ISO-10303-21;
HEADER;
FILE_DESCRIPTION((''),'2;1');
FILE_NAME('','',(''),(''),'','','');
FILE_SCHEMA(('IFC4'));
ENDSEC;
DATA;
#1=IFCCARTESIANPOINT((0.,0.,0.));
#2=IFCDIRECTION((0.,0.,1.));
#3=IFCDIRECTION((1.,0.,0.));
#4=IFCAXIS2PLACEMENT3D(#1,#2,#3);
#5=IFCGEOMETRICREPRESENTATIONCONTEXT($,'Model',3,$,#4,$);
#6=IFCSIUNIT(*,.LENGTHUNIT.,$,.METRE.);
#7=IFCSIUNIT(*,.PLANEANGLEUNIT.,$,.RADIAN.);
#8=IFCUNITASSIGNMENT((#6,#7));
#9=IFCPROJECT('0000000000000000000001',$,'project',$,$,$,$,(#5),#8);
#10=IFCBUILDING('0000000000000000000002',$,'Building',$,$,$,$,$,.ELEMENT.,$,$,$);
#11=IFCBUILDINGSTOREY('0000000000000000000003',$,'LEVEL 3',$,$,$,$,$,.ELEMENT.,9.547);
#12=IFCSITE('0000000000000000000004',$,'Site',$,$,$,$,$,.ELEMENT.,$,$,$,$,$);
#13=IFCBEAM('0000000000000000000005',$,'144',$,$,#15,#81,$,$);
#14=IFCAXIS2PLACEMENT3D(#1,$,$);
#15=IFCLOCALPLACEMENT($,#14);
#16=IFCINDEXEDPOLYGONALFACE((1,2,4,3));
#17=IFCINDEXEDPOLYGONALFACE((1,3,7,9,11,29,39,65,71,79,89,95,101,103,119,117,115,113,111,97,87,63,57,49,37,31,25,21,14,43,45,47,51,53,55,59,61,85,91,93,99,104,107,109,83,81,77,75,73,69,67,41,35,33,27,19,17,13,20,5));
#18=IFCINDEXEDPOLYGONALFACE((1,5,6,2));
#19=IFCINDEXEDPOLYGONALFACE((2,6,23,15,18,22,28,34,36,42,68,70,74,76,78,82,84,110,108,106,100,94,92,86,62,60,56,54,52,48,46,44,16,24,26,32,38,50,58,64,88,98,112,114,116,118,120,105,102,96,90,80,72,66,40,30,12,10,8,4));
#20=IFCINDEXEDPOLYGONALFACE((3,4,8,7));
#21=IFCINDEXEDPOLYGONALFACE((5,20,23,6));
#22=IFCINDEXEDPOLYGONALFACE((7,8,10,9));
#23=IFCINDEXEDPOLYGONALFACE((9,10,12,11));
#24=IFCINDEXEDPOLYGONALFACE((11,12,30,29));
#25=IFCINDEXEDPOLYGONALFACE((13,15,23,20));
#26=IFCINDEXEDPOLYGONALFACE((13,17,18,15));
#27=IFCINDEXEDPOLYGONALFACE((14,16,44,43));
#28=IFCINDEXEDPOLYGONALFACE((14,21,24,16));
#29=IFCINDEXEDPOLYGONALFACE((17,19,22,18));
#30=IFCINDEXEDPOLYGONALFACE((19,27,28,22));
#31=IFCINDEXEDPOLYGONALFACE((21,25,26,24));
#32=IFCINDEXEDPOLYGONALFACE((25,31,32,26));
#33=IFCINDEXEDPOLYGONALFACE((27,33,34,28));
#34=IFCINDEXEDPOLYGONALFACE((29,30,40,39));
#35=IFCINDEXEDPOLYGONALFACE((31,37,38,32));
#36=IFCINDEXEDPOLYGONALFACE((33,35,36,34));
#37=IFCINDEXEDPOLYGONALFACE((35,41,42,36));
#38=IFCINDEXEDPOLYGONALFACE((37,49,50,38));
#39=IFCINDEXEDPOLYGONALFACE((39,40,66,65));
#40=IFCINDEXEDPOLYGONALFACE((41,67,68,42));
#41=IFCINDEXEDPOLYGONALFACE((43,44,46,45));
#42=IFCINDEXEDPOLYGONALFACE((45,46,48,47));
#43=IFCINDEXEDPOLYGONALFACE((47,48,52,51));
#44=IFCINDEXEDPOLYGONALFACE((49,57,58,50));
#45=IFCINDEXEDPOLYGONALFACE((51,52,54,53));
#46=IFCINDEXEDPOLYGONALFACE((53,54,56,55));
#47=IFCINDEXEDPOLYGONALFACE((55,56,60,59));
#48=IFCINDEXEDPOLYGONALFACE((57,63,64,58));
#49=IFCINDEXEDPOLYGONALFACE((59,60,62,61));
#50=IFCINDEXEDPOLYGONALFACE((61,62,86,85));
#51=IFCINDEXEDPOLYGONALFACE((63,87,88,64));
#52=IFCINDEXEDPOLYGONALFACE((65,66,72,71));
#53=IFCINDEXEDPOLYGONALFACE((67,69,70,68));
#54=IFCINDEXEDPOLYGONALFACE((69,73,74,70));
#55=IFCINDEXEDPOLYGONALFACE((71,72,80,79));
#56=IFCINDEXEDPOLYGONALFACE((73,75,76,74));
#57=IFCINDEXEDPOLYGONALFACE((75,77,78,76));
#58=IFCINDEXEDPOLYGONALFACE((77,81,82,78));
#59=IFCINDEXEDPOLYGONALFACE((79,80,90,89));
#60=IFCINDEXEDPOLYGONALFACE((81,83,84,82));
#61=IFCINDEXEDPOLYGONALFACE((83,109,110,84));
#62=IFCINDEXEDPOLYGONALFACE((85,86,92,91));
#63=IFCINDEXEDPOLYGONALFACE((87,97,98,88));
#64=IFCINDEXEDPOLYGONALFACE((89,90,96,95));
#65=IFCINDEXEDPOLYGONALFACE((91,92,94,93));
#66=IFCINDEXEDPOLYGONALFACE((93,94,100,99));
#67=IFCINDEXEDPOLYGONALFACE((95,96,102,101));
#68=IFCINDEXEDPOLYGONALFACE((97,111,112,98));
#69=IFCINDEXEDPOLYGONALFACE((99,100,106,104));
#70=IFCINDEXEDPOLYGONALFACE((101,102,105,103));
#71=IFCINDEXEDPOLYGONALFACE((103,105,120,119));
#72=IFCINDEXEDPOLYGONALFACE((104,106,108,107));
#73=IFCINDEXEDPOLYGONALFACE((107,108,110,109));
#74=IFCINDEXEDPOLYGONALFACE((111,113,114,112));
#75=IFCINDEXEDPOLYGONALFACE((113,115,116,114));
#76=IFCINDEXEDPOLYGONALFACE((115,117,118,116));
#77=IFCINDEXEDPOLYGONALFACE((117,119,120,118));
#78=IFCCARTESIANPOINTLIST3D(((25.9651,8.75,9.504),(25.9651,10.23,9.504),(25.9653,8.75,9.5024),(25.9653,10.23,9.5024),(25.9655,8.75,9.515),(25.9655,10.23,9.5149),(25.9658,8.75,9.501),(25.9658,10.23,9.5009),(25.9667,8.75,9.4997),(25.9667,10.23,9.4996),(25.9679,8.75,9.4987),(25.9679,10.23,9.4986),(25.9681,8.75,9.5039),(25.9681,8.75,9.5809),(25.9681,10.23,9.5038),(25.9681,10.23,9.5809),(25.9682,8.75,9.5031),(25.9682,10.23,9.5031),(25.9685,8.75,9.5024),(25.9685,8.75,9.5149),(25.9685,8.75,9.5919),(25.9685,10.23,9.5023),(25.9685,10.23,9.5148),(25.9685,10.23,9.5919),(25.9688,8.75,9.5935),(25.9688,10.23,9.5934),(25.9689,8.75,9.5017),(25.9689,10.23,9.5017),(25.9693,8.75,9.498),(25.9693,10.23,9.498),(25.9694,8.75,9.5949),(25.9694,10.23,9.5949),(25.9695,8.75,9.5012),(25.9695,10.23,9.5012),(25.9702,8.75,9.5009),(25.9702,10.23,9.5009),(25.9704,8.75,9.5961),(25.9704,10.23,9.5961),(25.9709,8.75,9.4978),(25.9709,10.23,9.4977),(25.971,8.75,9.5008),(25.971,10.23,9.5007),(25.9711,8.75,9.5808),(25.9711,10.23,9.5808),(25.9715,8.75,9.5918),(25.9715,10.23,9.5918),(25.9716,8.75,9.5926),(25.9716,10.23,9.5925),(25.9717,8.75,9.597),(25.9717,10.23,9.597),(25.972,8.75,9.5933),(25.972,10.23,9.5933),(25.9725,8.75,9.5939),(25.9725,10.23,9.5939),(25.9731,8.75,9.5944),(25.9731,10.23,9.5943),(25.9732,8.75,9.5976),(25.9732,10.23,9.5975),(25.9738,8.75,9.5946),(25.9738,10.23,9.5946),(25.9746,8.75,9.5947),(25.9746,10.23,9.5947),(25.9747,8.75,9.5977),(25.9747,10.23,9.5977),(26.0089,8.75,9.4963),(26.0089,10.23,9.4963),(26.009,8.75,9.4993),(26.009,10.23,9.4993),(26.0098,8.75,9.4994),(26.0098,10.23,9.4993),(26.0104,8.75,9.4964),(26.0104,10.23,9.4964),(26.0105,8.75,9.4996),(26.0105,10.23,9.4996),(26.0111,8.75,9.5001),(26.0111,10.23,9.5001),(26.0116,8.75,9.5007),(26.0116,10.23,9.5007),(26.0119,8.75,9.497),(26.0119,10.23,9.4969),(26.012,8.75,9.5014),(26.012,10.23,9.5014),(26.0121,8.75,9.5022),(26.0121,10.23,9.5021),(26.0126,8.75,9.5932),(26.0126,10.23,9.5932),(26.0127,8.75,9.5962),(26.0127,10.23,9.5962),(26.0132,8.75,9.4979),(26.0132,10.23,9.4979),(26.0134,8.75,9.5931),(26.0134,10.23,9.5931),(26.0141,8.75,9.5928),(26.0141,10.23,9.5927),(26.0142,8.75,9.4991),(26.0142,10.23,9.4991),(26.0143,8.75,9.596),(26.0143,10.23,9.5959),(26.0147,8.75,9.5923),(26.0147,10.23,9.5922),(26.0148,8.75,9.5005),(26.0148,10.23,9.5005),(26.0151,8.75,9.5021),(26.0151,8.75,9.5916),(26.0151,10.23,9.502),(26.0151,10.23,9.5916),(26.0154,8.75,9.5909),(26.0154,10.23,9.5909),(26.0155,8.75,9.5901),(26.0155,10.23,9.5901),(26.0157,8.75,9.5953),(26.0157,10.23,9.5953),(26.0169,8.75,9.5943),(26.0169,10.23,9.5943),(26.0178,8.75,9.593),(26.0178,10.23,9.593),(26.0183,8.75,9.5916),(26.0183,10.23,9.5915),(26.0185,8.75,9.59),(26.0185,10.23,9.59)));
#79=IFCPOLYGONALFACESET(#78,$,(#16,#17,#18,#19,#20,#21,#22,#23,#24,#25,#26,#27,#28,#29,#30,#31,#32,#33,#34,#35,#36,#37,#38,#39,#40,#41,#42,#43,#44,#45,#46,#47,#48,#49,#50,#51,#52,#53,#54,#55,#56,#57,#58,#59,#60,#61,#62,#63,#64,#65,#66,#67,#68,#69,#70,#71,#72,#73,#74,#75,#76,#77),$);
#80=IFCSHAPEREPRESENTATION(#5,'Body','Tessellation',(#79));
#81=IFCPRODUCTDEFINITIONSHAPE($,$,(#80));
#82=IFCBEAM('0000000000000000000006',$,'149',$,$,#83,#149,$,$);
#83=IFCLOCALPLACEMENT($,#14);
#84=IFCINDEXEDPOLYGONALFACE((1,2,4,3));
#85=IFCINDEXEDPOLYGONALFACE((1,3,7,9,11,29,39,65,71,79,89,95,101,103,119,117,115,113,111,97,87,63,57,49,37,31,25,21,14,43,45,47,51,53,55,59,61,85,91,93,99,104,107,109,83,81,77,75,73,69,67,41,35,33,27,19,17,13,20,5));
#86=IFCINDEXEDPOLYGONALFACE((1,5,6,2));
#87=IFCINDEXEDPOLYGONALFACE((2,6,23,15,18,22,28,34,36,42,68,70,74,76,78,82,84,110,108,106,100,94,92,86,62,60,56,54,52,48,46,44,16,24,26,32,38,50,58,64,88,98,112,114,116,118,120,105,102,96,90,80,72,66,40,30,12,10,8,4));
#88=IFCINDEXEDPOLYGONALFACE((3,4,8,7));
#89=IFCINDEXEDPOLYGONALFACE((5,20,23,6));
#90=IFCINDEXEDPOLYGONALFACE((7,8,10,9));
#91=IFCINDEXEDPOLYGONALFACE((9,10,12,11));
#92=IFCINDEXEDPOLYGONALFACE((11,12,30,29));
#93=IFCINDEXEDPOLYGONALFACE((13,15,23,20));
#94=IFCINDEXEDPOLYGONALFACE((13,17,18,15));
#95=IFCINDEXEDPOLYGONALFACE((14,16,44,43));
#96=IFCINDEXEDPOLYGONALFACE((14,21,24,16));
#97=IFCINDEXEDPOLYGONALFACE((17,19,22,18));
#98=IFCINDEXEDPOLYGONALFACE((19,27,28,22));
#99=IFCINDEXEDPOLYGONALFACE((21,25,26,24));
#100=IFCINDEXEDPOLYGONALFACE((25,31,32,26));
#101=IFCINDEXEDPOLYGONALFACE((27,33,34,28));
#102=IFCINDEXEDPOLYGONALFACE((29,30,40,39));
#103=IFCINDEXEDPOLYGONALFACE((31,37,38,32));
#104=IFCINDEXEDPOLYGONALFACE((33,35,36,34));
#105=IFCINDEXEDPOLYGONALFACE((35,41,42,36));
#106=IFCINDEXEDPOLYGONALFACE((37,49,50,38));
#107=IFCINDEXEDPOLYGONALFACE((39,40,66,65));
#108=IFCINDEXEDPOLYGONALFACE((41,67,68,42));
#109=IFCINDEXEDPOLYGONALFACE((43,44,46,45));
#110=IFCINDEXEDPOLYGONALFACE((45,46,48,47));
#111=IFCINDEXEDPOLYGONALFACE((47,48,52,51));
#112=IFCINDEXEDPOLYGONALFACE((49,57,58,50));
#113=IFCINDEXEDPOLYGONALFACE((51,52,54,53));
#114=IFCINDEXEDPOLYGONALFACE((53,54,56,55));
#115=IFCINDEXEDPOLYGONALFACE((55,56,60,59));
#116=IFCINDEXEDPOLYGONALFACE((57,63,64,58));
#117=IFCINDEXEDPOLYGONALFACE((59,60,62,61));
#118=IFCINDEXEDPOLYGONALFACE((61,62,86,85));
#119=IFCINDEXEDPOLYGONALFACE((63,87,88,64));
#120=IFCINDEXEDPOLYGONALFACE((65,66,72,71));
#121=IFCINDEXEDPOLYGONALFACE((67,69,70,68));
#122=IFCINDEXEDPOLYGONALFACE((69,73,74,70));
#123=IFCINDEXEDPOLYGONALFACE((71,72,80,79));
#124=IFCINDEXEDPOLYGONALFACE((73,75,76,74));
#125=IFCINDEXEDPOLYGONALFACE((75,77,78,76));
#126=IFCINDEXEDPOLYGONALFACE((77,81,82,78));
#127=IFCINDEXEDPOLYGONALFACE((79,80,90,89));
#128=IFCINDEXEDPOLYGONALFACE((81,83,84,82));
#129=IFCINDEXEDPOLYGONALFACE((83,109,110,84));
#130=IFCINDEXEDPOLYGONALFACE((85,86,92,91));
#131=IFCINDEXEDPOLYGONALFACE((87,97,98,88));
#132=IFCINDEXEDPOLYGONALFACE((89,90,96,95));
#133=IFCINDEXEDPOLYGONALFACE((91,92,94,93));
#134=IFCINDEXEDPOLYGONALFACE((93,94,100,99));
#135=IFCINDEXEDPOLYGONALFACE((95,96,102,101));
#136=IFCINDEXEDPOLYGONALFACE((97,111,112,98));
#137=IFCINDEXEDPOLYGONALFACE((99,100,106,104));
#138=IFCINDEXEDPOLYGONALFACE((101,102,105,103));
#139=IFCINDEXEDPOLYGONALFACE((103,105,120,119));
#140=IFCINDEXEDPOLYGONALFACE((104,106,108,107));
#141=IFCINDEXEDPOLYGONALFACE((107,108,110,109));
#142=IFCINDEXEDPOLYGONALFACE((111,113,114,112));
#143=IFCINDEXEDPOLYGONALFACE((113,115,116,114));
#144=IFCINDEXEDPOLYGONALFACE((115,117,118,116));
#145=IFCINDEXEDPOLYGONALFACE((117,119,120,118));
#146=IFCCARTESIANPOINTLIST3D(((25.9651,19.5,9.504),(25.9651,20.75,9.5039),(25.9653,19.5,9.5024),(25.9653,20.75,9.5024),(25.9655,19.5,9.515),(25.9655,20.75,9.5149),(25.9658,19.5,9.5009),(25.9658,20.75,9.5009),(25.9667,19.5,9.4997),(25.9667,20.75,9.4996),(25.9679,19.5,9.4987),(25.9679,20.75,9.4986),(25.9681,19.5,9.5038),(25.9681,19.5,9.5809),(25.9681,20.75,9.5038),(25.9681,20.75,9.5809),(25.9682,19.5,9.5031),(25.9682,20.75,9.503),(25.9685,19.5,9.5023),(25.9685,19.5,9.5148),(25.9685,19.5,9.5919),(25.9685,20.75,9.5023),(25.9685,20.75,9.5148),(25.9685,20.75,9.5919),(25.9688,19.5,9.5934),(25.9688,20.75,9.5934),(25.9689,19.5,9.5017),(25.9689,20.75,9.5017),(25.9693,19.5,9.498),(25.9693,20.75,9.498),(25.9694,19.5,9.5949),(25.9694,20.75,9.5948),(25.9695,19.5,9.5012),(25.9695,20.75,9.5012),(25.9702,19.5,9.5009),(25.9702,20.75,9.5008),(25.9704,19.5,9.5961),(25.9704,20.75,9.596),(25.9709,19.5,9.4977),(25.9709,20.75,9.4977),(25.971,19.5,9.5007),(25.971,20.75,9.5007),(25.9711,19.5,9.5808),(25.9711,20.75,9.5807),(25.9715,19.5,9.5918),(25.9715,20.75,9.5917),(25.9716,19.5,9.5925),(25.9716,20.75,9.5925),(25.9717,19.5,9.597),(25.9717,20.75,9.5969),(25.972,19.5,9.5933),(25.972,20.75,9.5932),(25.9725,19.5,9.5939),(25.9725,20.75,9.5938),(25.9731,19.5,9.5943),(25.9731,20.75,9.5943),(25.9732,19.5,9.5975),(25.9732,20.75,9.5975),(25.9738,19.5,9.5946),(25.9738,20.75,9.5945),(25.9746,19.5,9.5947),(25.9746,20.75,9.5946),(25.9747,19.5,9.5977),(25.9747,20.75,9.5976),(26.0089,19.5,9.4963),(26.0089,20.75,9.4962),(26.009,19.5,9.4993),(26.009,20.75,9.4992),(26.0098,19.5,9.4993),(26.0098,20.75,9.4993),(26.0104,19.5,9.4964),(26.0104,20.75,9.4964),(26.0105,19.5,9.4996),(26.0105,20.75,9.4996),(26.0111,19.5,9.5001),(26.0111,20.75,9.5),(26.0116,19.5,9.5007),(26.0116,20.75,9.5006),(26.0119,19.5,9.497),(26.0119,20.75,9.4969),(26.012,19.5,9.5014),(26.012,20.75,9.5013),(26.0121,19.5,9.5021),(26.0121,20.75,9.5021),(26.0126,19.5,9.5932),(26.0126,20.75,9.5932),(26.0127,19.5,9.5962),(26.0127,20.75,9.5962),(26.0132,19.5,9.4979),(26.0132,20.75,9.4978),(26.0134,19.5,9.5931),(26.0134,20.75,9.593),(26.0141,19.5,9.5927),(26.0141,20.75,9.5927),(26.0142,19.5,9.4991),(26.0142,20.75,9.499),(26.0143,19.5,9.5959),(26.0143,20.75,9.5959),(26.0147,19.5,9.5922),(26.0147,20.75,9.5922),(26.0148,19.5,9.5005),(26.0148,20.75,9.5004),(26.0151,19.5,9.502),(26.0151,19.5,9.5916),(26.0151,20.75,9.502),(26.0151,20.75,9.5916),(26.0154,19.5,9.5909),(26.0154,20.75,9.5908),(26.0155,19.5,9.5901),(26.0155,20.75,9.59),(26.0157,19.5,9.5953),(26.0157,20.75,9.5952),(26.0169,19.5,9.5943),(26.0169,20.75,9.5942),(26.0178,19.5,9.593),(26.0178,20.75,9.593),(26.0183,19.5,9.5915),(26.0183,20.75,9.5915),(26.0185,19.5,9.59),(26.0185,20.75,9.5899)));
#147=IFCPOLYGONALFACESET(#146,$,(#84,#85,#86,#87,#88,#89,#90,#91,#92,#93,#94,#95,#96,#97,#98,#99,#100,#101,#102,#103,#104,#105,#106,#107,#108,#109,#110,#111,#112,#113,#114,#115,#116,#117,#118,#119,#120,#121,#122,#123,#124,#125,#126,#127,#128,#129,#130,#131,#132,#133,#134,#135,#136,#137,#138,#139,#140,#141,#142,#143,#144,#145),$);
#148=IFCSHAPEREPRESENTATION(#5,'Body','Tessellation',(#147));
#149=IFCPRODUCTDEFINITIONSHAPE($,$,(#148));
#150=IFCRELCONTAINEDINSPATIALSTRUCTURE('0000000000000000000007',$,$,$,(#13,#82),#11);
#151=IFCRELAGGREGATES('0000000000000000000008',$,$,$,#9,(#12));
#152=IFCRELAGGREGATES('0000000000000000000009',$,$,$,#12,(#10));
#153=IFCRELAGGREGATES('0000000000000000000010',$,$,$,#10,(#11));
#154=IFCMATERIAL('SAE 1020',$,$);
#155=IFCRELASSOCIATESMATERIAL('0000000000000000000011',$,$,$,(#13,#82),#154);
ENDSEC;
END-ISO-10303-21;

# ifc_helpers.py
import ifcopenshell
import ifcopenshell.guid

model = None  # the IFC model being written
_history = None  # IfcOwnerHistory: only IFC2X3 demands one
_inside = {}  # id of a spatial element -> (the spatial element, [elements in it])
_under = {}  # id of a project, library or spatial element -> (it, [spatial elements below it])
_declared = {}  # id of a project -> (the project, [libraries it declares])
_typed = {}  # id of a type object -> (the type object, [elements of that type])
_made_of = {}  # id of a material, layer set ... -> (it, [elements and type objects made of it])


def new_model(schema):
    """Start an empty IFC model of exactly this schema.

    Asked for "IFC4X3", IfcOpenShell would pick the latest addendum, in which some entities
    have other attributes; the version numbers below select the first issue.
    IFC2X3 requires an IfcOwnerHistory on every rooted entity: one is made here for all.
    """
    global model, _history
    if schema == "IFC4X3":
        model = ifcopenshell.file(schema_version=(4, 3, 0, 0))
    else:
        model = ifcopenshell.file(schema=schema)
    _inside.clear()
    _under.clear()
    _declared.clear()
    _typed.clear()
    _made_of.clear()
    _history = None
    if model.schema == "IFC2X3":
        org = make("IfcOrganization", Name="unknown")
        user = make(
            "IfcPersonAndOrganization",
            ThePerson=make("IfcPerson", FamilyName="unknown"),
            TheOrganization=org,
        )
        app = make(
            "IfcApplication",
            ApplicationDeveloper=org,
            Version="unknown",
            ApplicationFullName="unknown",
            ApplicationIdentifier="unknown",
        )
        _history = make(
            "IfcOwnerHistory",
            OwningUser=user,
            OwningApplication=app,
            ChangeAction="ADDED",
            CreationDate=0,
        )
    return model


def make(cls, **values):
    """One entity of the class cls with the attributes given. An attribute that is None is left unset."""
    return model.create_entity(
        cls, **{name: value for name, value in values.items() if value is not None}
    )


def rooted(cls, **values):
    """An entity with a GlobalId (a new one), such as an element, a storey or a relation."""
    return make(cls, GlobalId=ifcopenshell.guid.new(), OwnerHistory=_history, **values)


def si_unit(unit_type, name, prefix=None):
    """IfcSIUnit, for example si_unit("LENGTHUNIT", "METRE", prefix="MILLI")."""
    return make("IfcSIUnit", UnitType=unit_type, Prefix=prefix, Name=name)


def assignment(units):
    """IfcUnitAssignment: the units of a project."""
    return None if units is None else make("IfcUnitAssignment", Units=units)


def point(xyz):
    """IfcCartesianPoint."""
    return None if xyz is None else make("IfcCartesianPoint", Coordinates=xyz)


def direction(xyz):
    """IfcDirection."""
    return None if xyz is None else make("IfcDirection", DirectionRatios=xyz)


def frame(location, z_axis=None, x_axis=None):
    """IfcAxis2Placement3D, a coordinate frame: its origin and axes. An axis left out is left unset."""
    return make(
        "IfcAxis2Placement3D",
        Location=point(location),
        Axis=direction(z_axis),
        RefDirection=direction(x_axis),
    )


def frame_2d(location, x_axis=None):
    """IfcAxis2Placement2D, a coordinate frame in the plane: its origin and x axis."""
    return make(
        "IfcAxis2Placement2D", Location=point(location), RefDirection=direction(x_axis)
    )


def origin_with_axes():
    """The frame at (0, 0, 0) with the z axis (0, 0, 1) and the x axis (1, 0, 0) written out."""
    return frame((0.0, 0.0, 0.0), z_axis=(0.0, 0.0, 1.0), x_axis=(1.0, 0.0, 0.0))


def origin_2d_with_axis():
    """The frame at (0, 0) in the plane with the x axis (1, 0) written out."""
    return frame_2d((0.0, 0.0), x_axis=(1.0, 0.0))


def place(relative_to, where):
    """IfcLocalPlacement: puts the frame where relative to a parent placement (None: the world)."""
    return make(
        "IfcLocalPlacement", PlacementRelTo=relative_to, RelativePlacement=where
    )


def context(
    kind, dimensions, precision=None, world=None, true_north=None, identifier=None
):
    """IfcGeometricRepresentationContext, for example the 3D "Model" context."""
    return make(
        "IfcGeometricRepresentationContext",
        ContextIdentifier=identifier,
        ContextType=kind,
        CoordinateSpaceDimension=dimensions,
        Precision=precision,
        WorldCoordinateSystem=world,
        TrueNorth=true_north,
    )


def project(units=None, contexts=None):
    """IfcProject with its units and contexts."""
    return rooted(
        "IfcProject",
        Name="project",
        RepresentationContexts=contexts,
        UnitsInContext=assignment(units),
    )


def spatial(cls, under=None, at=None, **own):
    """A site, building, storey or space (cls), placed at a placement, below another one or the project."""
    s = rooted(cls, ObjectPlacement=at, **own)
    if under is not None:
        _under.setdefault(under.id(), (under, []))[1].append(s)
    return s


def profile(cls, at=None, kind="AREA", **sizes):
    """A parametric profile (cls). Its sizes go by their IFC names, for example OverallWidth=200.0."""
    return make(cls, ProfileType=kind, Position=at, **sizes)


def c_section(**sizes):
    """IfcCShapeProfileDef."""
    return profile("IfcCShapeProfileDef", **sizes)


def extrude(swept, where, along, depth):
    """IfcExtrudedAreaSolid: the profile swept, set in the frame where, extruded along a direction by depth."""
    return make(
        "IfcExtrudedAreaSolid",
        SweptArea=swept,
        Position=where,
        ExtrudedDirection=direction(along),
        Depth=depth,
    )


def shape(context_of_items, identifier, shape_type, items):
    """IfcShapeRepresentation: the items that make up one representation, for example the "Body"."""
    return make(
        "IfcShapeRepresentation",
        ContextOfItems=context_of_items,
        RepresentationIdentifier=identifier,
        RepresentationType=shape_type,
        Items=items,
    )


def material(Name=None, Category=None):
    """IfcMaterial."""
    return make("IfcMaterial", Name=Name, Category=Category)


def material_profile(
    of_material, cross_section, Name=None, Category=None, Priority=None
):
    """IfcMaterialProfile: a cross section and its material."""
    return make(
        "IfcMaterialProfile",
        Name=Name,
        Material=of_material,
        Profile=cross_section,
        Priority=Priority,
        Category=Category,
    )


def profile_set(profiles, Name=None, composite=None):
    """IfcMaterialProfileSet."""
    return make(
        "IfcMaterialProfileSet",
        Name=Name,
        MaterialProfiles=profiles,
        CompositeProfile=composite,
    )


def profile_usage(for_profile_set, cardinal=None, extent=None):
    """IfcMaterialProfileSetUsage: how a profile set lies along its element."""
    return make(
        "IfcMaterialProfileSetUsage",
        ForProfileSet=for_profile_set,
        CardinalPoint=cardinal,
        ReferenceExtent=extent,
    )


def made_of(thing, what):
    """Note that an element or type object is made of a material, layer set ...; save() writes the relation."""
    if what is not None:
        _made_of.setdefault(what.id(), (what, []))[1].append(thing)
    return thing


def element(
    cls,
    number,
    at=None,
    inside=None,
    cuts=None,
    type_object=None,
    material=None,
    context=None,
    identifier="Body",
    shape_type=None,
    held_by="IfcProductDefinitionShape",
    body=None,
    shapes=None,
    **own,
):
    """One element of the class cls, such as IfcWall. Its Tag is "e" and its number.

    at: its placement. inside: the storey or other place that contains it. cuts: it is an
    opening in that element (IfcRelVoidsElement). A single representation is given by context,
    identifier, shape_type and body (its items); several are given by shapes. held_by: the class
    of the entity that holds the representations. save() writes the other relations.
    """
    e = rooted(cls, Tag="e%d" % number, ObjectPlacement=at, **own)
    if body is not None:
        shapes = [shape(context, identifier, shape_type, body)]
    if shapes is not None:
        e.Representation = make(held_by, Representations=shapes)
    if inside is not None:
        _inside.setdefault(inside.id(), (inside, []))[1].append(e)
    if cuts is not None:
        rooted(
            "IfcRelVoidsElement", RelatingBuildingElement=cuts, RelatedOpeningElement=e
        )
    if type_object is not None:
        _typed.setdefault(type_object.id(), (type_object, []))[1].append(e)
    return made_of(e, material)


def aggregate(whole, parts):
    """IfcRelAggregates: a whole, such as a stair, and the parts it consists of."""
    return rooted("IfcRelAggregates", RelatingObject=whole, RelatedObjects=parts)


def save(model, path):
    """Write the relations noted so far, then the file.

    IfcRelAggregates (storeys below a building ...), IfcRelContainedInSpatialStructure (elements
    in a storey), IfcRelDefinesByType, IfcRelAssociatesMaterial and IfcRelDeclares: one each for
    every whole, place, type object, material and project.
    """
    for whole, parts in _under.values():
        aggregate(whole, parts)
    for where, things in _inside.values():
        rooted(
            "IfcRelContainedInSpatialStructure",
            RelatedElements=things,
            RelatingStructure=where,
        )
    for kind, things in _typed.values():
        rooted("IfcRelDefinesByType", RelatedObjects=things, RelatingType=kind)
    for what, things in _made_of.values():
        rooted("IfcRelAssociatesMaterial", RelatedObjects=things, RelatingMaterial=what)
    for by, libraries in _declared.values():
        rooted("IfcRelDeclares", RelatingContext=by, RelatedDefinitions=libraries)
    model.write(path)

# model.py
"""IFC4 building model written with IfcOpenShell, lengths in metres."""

from ifc_helpers import new_model, si_unit, frame, origin_with_axes, origin_2d_with_axis, place, context, project, spatial, c_section, extrude, material, material_profile, profile_set, profile_usage, element, save


model = new_model("IFC4")

# Units and contexts
model_context = context("Model", 3, world=origin_with_axes())
ifc_project = project(units=[si_unit("LENGTHUNIT", "METRE"), si_unit("PLANEANGLEUNIT", "RADIAN")], contexts=[model_context])

# Site, building, storey
site = spatial("IfcSite", under=ifc_project, Name="Site", CompositionType="ELEMENT")
building = spatial("IfcBuilding", under=site, Name="Building", CompositionType="ELEMENT")
storey = spatial("IfcBuildingStorey", under=building, Name="LEVEL 3", CompositionType="ELEMENT", Elevation=9.547)

# Beams
ifc_material = material(Name="SAE 1020")
ifc_material_profile_1 = material_profile(ifc_material, c_section(Depth=0.1, Width=0.05, WallThickness=0.003, Girth=0.017, InternalFilletRadius=0.003, at=origin_2d_with_axis()))
ifc_profile_set_1 = profile_set([ifc_material_profile_1])
ifc_profile_usage_1 = profile_usage(ifc_profile_set_1, cardinal=10)
beam_1_placement = place(None, frame((25.9918, 8.75, 9.547), z_axis=(0.0, 1.0, -0.00003), x_axis=(-0.999256, 0.000001, 0.038562)))
element("IfcBeam", 1, at=beam_1_placement, inside=storey, material=ifc_profile_usage_1, Name="144", context=model_context, shape_type="SweptSolid", body=[
    extrude(c_section(Depth=0.1, Width=0.05, WallThickness=0.003, Girth=0.017, InternalFilletRadius=0.003, at=origin_2d_with_axis()), origin_with_axes(), (0.0, 0.0, 1.0), 1.48),
])
ifc_material_profile_2 = material_profile(ifc_material, c_section(Depth=0.1, Width=0.05, WallThickness=0.003, Girth=0.017, InternalFilletRadius=0.003, at=origin_2d_with_axis()))
ifc_profile_set_2 = profile_set([ifc_material_profile_2])
ifc_profile_usage_2 = profile_usage(ifc_profile_set_2, cardinal=10)
beam_2_placement = place(None, frame((25.9918, 19.5, 9.547), z_axis=(0.0, 1.0, -0.00003), x_axis=(-0.999256, 0.000001, 0.038562)))
element("IfcBeam", 2, at=beam_2_placement, inside=storey, material=ifc_profile_usage_2, Name="149", context=model_context, shape_type="SweptSolid", body=[
    extrude(c_section(Depth=0.1, Width=0.05, WallThickness=0.003, Girth=0.017, InternalFilletRadius=0.003, at=origin_2d_with_axis()), origin_with_axes(), (0.0, 0.0, 1.0), 1.25),
])

save(model, "model.ifc")
